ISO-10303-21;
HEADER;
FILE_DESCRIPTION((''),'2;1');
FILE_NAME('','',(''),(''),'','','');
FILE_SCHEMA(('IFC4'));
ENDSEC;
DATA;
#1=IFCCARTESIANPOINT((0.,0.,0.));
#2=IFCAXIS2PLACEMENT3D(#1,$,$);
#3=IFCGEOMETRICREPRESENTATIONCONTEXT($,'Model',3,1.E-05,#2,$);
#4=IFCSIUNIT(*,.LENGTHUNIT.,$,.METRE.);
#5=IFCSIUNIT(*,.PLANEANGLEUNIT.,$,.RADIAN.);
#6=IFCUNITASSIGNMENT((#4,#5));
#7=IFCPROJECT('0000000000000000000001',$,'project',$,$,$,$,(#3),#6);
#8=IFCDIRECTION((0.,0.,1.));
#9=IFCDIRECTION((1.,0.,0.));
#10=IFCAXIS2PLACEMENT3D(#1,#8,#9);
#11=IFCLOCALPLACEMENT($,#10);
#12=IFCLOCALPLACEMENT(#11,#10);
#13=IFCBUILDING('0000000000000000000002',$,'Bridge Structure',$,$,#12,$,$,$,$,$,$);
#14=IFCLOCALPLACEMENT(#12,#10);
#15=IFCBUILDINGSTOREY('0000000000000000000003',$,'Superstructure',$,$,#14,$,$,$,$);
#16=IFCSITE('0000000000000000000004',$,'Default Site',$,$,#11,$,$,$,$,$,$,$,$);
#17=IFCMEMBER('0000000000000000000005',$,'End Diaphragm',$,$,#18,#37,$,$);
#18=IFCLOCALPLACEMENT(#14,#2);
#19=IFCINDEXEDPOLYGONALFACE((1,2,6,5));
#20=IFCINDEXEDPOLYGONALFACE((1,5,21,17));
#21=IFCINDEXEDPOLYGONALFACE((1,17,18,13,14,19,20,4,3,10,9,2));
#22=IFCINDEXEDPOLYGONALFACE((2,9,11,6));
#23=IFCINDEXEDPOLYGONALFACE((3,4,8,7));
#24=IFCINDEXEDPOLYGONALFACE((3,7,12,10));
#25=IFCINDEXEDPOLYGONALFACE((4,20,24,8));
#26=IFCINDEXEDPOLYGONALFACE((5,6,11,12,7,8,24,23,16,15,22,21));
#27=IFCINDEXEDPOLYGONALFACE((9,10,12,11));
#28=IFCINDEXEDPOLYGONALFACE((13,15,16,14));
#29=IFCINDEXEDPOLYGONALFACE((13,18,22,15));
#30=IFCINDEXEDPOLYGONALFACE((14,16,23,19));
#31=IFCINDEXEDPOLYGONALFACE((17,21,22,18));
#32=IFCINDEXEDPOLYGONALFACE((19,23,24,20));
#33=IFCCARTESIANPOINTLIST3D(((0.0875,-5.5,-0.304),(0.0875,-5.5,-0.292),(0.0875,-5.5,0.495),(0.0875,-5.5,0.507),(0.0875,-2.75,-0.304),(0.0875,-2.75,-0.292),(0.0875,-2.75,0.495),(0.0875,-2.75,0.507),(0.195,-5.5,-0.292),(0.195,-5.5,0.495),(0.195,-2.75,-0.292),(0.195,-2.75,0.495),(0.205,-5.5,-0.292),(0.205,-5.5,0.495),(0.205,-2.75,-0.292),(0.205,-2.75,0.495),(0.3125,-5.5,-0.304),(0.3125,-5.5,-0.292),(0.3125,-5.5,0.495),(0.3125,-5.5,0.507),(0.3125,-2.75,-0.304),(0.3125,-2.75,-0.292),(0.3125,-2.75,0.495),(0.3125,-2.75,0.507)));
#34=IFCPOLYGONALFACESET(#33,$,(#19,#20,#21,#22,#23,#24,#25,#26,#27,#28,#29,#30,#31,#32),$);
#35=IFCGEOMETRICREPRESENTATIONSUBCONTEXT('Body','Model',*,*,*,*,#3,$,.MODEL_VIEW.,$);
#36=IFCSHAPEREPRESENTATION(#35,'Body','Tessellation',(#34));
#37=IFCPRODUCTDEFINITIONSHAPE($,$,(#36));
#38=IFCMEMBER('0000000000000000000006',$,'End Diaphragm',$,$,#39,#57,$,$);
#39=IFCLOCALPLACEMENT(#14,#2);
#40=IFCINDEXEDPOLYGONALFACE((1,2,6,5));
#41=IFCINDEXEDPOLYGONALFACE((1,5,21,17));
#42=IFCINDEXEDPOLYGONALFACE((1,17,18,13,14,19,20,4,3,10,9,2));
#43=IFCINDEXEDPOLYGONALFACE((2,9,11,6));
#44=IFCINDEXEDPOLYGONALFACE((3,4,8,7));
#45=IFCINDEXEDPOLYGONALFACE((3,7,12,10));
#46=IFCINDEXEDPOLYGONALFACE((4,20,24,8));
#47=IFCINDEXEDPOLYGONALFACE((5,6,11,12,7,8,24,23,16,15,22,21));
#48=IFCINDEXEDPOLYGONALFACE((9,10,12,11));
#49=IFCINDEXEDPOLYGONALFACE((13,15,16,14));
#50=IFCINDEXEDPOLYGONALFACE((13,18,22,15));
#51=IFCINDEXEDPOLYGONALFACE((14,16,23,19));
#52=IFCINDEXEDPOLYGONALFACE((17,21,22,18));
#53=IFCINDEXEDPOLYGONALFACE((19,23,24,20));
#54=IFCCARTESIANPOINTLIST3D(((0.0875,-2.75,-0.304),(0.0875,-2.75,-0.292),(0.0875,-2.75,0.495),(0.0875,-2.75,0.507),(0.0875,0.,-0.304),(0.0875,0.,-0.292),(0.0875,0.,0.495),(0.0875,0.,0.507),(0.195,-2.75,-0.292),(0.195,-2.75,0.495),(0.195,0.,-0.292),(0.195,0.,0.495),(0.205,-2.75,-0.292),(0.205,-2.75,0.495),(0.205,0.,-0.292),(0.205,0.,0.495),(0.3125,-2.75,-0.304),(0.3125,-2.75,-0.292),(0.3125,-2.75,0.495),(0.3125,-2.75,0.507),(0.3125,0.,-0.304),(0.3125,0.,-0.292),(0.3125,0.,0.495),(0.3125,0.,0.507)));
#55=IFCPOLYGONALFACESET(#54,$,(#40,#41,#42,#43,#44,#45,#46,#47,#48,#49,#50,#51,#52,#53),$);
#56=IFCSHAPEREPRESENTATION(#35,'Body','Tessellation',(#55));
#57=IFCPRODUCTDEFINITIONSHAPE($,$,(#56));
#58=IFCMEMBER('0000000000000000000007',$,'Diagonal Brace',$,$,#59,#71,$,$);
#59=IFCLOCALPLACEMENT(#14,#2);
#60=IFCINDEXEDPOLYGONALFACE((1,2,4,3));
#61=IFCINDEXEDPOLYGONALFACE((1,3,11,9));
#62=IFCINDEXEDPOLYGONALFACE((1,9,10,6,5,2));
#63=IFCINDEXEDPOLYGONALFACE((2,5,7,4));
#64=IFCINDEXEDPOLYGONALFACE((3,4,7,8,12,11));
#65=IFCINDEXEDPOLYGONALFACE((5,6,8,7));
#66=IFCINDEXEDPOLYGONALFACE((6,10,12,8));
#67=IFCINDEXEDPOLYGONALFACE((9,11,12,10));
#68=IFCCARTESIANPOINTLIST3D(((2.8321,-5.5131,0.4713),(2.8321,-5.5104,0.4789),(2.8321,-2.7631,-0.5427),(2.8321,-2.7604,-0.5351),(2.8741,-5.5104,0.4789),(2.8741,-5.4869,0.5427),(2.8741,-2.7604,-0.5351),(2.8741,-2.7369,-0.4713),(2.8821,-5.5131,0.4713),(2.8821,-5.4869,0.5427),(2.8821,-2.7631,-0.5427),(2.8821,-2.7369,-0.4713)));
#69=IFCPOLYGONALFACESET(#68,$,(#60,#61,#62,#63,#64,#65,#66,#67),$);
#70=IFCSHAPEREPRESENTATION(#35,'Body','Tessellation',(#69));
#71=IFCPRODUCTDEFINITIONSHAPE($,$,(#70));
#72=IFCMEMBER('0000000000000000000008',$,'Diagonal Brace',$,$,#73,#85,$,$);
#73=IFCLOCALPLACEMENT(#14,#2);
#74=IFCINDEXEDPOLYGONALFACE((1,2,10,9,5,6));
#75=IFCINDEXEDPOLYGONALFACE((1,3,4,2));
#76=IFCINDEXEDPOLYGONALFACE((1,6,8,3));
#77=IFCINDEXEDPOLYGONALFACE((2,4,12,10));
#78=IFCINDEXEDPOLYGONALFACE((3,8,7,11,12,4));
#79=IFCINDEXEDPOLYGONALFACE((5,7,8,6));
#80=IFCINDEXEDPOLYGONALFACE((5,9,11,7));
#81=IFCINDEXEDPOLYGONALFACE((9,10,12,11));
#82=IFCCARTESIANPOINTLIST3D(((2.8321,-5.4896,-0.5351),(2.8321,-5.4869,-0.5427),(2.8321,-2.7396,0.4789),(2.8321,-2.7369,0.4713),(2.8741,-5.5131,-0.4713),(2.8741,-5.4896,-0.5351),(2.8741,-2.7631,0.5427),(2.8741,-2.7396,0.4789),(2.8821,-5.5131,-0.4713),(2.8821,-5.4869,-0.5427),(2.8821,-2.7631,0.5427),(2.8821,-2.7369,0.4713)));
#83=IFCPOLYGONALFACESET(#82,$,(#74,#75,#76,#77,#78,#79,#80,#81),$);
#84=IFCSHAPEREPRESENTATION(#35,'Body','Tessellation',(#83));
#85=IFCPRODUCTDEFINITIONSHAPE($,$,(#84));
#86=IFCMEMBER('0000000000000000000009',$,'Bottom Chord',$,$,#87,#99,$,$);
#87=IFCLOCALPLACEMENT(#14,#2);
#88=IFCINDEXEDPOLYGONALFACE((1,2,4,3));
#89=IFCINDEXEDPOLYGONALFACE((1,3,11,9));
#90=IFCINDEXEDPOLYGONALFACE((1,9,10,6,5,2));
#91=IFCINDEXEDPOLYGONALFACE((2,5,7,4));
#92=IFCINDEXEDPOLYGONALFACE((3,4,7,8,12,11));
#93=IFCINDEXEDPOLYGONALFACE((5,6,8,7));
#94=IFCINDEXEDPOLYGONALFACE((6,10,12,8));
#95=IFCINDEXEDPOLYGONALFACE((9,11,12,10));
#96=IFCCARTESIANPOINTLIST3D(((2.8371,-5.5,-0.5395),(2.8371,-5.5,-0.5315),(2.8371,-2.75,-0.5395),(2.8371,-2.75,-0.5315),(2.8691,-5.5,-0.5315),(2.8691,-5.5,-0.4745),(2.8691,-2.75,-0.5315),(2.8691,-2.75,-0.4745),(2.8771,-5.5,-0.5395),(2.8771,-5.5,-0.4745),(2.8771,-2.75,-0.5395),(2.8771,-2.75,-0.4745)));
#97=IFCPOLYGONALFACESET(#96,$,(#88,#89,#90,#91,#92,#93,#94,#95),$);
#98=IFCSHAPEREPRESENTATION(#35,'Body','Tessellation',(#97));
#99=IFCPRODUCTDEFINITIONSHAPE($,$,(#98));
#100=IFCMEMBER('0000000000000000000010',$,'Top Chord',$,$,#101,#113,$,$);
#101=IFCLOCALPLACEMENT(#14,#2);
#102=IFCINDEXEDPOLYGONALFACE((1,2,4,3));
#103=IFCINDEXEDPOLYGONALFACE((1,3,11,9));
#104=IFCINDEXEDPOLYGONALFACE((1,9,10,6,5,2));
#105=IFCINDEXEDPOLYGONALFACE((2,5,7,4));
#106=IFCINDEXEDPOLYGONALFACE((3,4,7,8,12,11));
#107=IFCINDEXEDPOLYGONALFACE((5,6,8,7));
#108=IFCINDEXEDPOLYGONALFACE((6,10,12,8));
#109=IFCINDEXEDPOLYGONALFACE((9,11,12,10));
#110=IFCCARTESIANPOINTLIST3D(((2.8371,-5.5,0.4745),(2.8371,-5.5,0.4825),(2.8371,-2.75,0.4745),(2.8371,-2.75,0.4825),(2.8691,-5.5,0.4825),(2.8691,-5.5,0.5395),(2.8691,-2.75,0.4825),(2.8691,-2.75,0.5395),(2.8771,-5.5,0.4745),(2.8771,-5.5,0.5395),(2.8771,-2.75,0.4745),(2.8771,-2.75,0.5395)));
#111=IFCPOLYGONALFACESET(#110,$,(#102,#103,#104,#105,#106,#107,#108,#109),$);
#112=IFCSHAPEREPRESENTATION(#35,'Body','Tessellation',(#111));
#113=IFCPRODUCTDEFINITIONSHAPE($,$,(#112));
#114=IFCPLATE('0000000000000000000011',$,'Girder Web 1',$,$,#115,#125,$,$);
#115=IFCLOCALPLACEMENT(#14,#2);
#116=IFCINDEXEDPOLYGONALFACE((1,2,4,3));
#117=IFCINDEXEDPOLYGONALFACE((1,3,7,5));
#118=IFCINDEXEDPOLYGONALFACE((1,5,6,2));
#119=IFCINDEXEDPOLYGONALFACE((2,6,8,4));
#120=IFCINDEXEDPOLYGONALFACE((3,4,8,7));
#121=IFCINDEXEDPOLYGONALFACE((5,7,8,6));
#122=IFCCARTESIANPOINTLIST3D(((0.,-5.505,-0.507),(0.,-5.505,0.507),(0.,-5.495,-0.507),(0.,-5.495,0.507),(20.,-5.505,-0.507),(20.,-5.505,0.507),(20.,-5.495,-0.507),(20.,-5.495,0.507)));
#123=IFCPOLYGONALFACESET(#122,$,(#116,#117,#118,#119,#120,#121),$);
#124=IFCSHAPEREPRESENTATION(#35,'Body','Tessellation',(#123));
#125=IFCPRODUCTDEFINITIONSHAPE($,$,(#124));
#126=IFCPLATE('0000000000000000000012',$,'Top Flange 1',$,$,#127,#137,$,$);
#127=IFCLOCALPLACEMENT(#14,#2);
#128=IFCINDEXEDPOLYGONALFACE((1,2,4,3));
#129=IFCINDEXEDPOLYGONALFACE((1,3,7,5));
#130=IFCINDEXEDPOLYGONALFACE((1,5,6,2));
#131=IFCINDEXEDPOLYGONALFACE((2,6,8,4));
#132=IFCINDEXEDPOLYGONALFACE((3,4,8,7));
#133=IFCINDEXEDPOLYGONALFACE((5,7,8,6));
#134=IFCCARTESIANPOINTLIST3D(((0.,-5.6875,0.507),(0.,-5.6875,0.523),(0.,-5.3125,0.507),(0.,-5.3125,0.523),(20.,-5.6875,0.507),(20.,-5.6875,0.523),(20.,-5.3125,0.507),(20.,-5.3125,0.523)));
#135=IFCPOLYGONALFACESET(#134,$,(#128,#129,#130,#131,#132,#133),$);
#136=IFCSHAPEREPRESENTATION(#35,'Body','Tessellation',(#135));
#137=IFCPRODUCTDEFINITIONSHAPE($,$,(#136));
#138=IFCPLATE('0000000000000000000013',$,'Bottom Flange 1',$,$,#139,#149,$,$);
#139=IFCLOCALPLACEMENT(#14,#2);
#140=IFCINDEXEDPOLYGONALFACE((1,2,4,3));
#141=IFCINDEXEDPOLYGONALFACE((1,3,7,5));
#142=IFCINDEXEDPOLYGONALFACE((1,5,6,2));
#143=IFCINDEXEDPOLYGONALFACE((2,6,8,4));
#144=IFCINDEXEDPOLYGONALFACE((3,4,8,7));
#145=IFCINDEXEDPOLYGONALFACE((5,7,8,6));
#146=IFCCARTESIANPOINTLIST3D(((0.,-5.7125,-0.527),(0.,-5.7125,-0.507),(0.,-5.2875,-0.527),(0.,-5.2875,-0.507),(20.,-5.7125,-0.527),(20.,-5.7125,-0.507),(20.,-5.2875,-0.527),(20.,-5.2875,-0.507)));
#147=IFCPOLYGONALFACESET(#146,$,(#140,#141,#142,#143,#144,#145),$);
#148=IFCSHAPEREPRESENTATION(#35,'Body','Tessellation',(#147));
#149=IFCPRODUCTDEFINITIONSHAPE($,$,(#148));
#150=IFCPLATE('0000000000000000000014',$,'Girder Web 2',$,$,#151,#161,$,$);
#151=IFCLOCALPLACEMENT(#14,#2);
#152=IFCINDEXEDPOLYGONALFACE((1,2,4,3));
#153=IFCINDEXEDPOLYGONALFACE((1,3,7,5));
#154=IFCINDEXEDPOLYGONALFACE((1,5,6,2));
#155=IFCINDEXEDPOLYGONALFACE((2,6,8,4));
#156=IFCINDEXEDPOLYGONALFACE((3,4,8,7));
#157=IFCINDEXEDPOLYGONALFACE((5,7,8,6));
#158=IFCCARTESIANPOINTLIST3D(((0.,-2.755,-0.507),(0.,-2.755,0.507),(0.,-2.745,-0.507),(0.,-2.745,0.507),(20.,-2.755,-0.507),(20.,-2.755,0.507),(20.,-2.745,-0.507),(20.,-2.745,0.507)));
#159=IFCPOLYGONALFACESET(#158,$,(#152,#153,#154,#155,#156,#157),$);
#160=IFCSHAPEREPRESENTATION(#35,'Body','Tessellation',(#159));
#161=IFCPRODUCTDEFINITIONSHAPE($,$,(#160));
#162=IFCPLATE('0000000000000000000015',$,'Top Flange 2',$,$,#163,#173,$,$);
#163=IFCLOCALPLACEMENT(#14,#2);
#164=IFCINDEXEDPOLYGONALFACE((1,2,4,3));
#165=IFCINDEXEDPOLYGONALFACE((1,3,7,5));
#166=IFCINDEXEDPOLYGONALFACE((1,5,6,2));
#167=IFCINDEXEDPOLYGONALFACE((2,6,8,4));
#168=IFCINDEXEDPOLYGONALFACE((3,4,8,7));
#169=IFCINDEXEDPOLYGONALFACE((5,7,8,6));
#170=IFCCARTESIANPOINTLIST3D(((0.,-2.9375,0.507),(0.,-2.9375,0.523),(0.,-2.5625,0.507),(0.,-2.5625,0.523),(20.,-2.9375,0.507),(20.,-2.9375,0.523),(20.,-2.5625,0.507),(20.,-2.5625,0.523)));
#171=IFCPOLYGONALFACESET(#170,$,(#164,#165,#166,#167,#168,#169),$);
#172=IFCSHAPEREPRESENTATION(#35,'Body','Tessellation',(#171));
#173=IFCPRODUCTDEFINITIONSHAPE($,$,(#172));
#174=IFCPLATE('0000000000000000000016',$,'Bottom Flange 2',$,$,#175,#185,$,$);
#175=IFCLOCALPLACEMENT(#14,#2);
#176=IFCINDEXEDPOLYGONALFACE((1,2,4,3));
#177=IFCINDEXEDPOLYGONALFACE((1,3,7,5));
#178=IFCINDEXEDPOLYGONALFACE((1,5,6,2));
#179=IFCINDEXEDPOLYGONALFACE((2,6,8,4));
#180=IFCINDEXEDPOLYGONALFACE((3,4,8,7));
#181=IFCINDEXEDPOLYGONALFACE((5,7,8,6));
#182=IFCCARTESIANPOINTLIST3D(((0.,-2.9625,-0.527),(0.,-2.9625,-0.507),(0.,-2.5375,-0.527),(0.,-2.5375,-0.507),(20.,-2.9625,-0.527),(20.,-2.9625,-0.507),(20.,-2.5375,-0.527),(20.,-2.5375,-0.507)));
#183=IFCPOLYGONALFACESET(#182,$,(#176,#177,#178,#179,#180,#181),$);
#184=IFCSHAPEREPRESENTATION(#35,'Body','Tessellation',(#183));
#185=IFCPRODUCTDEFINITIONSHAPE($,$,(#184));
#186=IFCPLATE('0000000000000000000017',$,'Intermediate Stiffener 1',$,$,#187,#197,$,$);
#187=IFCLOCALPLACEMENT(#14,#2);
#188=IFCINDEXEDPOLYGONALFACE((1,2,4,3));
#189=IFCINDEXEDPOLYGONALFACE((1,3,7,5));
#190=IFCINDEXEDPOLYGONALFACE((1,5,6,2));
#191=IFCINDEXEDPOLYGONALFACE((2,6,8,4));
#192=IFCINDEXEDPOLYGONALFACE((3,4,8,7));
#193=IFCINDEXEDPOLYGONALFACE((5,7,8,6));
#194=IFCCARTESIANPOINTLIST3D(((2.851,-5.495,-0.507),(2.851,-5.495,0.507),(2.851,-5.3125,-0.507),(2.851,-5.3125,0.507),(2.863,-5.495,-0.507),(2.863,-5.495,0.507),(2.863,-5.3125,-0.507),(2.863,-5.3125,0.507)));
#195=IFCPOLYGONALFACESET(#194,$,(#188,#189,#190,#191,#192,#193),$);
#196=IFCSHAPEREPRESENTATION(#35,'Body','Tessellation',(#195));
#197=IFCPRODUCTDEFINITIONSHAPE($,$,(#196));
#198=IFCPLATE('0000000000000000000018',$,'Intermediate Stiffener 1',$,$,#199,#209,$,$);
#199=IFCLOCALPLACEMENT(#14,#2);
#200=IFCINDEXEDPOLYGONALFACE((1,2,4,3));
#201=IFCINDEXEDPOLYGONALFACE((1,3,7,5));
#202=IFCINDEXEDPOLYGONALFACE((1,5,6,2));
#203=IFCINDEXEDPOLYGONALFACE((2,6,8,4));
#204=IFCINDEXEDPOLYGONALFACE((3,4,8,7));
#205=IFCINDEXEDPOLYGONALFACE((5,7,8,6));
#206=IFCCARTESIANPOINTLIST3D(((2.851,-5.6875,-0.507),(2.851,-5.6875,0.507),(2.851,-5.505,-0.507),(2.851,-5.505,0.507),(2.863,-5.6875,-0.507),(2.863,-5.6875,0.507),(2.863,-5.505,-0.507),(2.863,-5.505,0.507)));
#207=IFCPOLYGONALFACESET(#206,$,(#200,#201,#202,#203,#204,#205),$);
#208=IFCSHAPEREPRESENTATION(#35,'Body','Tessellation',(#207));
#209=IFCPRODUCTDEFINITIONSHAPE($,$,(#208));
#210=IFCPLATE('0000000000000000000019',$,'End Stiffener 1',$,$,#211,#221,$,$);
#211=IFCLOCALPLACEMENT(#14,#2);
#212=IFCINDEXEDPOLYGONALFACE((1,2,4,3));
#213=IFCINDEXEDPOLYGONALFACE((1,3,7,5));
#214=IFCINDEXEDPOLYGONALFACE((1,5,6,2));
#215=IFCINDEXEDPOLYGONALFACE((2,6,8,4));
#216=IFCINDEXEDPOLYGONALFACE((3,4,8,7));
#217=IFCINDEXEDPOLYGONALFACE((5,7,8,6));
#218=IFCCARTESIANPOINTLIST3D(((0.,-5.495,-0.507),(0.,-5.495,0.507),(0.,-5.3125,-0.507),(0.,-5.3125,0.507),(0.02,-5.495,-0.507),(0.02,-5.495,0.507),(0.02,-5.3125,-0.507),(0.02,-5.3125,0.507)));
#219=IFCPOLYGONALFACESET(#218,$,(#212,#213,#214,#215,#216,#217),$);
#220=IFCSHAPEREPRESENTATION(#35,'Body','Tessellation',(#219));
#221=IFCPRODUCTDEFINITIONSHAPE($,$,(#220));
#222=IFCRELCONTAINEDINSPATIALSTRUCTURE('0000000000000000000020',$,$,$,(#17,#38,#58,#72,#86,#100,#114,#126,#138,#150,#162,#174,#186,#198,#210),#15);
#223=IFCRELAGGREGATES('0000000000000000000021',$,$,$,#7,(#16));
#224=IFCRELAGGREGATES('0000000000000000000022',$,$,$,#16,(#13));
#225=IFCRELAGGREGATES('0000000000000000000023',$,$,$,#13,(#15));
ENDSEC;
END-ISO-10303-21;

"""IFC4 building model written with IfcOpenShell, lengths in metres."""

from ifc_helpers import new_model, si_unit, frame, origin, origin_with_axes, origin_2d_with_axis, place, context, subcontext, project, spatial, rectangle, i_section, l_section, extrude, element, save


model = new_model("IFC4")

# Units and contexts
model_context = context("Model", 3, precision=1e-05, world=origin())
body_context = subcontext(model_context, "Body", "Model", "MODEL_VIEW")
ifc_project = project(units=[si_unit("LENGTHUNIT", "METRE"), si_unit("PLANEANGLEUNIT", "RADIAN")], contexts=[model_context])

# Site, building, storey
site_placement = place(None, origin_with_axes())
site = spatial("IfcSite", under=ifc_project, at=site_placement, Name="Default Site")
building_placement = place(site_placement, origin_with_axes())
building = spatial("IfcBuilding", under=site, at=building_placement, Name="Bridge Structure")
storey_placement = place(building_placement, origin_with_axes())
storey = spatial("IfcBuildingStorey", under=building, at=storey_placement, Name="Superstructure")

# Members
for number, where, z_axis, x_axis, name in (
    (1, (0.2, -5.5, 0.1015), (0.0, 1.0, 0.0), (-1.0, 0.0, 0.0), "End Diaphragm"),
    (2, (0.2, -2.75, 0.1015), (0.0, 1.0, 0.0), (-1.0, 0.0, 0.0), "End Diaphragm"),
):
    element("IfcMember", number, at=place(storey_placement, frame(where, z_axis=z_axis, x_axis=x_axis)), inside=storey, Name=name, context=body_context, shape_type="SweptSolid", body=[
        extrude(i_section(OverallWidth=0.225, OverallDepth=0.811, WebThickness=0.01, FlangeThickness=0.012, at=origin_2d_with_axis()), origin_with_axes(), (0.0, 0.0, 1.0), 2.75),
    ])
for number, where, z_axis, x_axis, name in (
    (3, (2.8571, -5.5, 0.507), (0.0, 0.93825, -0.345958), (-1.0, 0.0, 0.0), "Diagonal Brace"),
    (4, (2.8571, -5.5, -0.507), (0.0, 0.93825, 0.345958), (-1.0, 0.0, 0.0), "Diagonal Brace"),
):
    element("IfcMember", number, at=place(storey_placement, frame(where, z_axis=z_axis, x_axis=x_axis)), inside=storey, Name=name, context=body_context, shape_type="SweptSolid", body=[
        extrude(l_section(Depth=0.076, Width=0.05, Thickness=0.008, at=origin_2d_with_axis()), origin_with_axes(), (0.0, 0.0, 1.0), 2.931),
    ])
for number, where, z_axis, x_axis, name in (
    (5, (2.8571, -5.5, -0.507), (0.0, 1.0, 0.0), (-1.0, 0.0, 0.0), "Bottom Chord"),
    (6, (2.8571, -5.5, 0.507), (0.0, 1.0, 0.0), (-1.0, 0.0, 0.0), "Top Chord"),
):
    element("IfcMember", number, at=place(storey_placement, frame(where, z_axis=z_axis, x_axis=x_axis)), inside=storey, Name=name, context=body_context, shape_type="SweptSolid", body=[
        extrude(l_section(Depth=0.065, Width=0.04, Thickness=0.008, at=origin_2d_with_axis()), origin_with_axes(), (0.0, 0.0, 1.0), 2.75),
    ])

# Plates
plate_1_placement = place(storey_placement, frame((0.0, -5.5, 0.0), z_axis=(1.0, 0.0, 0.0), x_axis=(0.0, 1.0, 0.0)))
element("IfcPlate", 7, at=plate_1_placement, inside=storey, Name="Girder Web 1", context=body_context, shape_type="SweptSolid", body=[
    extrude(rectangle(XDim=0.01, YDim=1.014, at=origin_2d_with_axis()), origin_with_axes(), (0.0, 0.0, 1.0), 20.0),
])
plate_2_placement = place(storey_placement, frame((0.0, -5.5, 0.515), z_axis=(1.0, 0.0, 0.0), x_axis=(0.0, 1.0, 0.0)))
element("IfcPlate", 8, at=plate_2_placement, inside=storey, Name="Top Flange 1", context=body_context, shape_type="SweptSolid", body=[
    extrude(rectangle(XDim=0.375, YDim=0.016, at=origin_2d_with_axis()), origin_with_axes(), (0.0, 0.0, 1.0), 20.0),
])
plate_3_placement = place(storey_placement, frame((0.0, -5.5, -0.517), z_axis=(1.0, 0.0, 0.0), x_axis=(0.0, 1.0, 0.0)))
element("IfcPlate", 9, at=plate_3_placement, inside=storey, Name="Bottom Flange 1", context=body_context, shape_type="SweptSolid", body=[
    extrude(rectangle(XDim=0.425, YDim=0.02, at=origin_2d_with_axis()), origin_with_axes(), (0.0, 0.0, 1.0), 20.0),
])
plate_4_placement = place(storey_placement, frame((0.0, -2.75, 0.0), z_axis=(1.0, 0.0, 0.0), x_axis=(0.0, 1.0, 0.0)))
element("IfcPlate", 10, at=plate_4_placement, inside=storey, Name="Girder Web 2", context=body_context, shape_type="SweptSolid", body=[
    extrude(rectangle(XDim=0.01, YDim=1.014, at=origin_2d_with_axis()), origin_with_axes(), (0.0, 0.0, 1.0), 20.0),
])
plate_5_placement = place(storey_placement, frame((0.0, -2.75, 0.515), z_axis=(1.0, 0.0, 0.0), x_axis=(0.0, 1.0, 0.0)))
element("IfcPlate", 11, at=plate_5_placement, inside=storey, Name="Top Flange 2", context=body_context, shape_type="SweptSolid", body=[
    extrude(rectangle(XDim=0.375, YDim=0.016, at=origin_2d_with_axis()), origin_with_axes(), (0.0, 0.0, 1.0), 20.0),
])
plate_6_placement = place(storey_placement, frame((0.0, -2.75, -0.517), z_axis=(1.0, 0.0, 0.0), x_axis=(0.0, 1.0, 0.0)))
element("IfcPlate", 12, at=plate_6_placement, inside=storey, Name="Bottom Flange 2", context=body_context, shape_type="SweptSolid", body=[
    extrude(rectangle(XDim=0.425, YDim=0.02, at=origin_2d_with_axis()), origin_with_axes(), (0.0, 0.0, 1.0), 20.0),
])
for number, where, z_axis, x_axis, name in (
    (13, (2.857, -5.4038, -0.507), (0.0, 0.0, 1.0), (1.0, 0.0, 0.0), "Intermediate Stiffener 1"),
    (14, (2.857, -5.5963, -0.507), (0.0, 0.0, 1.0), (1.0, 0.0, 0.0), "Intermediate Stiffener 1"),
):
    element("IfcPlate", number, at=place(storey_placement, frame(where, z_axis=z_axis, x_axis=x_axis)), inside=storey, Name=name, context=body_context, shape_type="SweptSolid", body=[
        extrude(rectangle(XDim=0.012, YDim=0.1825, at=origin_2d_with_axis()), origin_with_axes(), (0.0, 0.0, 1.0), 1.014),
    ])
for number, where, z_axis, x_axis, name in (
    (15, (0.01, -5.4038, -0.507), (0.0, 0.0, 1.0), (1.0, 0.0, 0.0), "End Stiffener 1"),
):
    element("IfcPlate", number, at=place(storey_placement, frame(where, z_axis=z_axis, x_axis=x_axis)), inside=storey, Name=name, context=body_context, shape_type="SweptSolid", body=[
        extrude(rectangle(XDim=0.02, YDim=0.1825, at=origin_2d_with_axis()), origin_with_axes(), (0.0, 0.0, 1.0), 1.014),
    ])

save(model, "model.ifc")
